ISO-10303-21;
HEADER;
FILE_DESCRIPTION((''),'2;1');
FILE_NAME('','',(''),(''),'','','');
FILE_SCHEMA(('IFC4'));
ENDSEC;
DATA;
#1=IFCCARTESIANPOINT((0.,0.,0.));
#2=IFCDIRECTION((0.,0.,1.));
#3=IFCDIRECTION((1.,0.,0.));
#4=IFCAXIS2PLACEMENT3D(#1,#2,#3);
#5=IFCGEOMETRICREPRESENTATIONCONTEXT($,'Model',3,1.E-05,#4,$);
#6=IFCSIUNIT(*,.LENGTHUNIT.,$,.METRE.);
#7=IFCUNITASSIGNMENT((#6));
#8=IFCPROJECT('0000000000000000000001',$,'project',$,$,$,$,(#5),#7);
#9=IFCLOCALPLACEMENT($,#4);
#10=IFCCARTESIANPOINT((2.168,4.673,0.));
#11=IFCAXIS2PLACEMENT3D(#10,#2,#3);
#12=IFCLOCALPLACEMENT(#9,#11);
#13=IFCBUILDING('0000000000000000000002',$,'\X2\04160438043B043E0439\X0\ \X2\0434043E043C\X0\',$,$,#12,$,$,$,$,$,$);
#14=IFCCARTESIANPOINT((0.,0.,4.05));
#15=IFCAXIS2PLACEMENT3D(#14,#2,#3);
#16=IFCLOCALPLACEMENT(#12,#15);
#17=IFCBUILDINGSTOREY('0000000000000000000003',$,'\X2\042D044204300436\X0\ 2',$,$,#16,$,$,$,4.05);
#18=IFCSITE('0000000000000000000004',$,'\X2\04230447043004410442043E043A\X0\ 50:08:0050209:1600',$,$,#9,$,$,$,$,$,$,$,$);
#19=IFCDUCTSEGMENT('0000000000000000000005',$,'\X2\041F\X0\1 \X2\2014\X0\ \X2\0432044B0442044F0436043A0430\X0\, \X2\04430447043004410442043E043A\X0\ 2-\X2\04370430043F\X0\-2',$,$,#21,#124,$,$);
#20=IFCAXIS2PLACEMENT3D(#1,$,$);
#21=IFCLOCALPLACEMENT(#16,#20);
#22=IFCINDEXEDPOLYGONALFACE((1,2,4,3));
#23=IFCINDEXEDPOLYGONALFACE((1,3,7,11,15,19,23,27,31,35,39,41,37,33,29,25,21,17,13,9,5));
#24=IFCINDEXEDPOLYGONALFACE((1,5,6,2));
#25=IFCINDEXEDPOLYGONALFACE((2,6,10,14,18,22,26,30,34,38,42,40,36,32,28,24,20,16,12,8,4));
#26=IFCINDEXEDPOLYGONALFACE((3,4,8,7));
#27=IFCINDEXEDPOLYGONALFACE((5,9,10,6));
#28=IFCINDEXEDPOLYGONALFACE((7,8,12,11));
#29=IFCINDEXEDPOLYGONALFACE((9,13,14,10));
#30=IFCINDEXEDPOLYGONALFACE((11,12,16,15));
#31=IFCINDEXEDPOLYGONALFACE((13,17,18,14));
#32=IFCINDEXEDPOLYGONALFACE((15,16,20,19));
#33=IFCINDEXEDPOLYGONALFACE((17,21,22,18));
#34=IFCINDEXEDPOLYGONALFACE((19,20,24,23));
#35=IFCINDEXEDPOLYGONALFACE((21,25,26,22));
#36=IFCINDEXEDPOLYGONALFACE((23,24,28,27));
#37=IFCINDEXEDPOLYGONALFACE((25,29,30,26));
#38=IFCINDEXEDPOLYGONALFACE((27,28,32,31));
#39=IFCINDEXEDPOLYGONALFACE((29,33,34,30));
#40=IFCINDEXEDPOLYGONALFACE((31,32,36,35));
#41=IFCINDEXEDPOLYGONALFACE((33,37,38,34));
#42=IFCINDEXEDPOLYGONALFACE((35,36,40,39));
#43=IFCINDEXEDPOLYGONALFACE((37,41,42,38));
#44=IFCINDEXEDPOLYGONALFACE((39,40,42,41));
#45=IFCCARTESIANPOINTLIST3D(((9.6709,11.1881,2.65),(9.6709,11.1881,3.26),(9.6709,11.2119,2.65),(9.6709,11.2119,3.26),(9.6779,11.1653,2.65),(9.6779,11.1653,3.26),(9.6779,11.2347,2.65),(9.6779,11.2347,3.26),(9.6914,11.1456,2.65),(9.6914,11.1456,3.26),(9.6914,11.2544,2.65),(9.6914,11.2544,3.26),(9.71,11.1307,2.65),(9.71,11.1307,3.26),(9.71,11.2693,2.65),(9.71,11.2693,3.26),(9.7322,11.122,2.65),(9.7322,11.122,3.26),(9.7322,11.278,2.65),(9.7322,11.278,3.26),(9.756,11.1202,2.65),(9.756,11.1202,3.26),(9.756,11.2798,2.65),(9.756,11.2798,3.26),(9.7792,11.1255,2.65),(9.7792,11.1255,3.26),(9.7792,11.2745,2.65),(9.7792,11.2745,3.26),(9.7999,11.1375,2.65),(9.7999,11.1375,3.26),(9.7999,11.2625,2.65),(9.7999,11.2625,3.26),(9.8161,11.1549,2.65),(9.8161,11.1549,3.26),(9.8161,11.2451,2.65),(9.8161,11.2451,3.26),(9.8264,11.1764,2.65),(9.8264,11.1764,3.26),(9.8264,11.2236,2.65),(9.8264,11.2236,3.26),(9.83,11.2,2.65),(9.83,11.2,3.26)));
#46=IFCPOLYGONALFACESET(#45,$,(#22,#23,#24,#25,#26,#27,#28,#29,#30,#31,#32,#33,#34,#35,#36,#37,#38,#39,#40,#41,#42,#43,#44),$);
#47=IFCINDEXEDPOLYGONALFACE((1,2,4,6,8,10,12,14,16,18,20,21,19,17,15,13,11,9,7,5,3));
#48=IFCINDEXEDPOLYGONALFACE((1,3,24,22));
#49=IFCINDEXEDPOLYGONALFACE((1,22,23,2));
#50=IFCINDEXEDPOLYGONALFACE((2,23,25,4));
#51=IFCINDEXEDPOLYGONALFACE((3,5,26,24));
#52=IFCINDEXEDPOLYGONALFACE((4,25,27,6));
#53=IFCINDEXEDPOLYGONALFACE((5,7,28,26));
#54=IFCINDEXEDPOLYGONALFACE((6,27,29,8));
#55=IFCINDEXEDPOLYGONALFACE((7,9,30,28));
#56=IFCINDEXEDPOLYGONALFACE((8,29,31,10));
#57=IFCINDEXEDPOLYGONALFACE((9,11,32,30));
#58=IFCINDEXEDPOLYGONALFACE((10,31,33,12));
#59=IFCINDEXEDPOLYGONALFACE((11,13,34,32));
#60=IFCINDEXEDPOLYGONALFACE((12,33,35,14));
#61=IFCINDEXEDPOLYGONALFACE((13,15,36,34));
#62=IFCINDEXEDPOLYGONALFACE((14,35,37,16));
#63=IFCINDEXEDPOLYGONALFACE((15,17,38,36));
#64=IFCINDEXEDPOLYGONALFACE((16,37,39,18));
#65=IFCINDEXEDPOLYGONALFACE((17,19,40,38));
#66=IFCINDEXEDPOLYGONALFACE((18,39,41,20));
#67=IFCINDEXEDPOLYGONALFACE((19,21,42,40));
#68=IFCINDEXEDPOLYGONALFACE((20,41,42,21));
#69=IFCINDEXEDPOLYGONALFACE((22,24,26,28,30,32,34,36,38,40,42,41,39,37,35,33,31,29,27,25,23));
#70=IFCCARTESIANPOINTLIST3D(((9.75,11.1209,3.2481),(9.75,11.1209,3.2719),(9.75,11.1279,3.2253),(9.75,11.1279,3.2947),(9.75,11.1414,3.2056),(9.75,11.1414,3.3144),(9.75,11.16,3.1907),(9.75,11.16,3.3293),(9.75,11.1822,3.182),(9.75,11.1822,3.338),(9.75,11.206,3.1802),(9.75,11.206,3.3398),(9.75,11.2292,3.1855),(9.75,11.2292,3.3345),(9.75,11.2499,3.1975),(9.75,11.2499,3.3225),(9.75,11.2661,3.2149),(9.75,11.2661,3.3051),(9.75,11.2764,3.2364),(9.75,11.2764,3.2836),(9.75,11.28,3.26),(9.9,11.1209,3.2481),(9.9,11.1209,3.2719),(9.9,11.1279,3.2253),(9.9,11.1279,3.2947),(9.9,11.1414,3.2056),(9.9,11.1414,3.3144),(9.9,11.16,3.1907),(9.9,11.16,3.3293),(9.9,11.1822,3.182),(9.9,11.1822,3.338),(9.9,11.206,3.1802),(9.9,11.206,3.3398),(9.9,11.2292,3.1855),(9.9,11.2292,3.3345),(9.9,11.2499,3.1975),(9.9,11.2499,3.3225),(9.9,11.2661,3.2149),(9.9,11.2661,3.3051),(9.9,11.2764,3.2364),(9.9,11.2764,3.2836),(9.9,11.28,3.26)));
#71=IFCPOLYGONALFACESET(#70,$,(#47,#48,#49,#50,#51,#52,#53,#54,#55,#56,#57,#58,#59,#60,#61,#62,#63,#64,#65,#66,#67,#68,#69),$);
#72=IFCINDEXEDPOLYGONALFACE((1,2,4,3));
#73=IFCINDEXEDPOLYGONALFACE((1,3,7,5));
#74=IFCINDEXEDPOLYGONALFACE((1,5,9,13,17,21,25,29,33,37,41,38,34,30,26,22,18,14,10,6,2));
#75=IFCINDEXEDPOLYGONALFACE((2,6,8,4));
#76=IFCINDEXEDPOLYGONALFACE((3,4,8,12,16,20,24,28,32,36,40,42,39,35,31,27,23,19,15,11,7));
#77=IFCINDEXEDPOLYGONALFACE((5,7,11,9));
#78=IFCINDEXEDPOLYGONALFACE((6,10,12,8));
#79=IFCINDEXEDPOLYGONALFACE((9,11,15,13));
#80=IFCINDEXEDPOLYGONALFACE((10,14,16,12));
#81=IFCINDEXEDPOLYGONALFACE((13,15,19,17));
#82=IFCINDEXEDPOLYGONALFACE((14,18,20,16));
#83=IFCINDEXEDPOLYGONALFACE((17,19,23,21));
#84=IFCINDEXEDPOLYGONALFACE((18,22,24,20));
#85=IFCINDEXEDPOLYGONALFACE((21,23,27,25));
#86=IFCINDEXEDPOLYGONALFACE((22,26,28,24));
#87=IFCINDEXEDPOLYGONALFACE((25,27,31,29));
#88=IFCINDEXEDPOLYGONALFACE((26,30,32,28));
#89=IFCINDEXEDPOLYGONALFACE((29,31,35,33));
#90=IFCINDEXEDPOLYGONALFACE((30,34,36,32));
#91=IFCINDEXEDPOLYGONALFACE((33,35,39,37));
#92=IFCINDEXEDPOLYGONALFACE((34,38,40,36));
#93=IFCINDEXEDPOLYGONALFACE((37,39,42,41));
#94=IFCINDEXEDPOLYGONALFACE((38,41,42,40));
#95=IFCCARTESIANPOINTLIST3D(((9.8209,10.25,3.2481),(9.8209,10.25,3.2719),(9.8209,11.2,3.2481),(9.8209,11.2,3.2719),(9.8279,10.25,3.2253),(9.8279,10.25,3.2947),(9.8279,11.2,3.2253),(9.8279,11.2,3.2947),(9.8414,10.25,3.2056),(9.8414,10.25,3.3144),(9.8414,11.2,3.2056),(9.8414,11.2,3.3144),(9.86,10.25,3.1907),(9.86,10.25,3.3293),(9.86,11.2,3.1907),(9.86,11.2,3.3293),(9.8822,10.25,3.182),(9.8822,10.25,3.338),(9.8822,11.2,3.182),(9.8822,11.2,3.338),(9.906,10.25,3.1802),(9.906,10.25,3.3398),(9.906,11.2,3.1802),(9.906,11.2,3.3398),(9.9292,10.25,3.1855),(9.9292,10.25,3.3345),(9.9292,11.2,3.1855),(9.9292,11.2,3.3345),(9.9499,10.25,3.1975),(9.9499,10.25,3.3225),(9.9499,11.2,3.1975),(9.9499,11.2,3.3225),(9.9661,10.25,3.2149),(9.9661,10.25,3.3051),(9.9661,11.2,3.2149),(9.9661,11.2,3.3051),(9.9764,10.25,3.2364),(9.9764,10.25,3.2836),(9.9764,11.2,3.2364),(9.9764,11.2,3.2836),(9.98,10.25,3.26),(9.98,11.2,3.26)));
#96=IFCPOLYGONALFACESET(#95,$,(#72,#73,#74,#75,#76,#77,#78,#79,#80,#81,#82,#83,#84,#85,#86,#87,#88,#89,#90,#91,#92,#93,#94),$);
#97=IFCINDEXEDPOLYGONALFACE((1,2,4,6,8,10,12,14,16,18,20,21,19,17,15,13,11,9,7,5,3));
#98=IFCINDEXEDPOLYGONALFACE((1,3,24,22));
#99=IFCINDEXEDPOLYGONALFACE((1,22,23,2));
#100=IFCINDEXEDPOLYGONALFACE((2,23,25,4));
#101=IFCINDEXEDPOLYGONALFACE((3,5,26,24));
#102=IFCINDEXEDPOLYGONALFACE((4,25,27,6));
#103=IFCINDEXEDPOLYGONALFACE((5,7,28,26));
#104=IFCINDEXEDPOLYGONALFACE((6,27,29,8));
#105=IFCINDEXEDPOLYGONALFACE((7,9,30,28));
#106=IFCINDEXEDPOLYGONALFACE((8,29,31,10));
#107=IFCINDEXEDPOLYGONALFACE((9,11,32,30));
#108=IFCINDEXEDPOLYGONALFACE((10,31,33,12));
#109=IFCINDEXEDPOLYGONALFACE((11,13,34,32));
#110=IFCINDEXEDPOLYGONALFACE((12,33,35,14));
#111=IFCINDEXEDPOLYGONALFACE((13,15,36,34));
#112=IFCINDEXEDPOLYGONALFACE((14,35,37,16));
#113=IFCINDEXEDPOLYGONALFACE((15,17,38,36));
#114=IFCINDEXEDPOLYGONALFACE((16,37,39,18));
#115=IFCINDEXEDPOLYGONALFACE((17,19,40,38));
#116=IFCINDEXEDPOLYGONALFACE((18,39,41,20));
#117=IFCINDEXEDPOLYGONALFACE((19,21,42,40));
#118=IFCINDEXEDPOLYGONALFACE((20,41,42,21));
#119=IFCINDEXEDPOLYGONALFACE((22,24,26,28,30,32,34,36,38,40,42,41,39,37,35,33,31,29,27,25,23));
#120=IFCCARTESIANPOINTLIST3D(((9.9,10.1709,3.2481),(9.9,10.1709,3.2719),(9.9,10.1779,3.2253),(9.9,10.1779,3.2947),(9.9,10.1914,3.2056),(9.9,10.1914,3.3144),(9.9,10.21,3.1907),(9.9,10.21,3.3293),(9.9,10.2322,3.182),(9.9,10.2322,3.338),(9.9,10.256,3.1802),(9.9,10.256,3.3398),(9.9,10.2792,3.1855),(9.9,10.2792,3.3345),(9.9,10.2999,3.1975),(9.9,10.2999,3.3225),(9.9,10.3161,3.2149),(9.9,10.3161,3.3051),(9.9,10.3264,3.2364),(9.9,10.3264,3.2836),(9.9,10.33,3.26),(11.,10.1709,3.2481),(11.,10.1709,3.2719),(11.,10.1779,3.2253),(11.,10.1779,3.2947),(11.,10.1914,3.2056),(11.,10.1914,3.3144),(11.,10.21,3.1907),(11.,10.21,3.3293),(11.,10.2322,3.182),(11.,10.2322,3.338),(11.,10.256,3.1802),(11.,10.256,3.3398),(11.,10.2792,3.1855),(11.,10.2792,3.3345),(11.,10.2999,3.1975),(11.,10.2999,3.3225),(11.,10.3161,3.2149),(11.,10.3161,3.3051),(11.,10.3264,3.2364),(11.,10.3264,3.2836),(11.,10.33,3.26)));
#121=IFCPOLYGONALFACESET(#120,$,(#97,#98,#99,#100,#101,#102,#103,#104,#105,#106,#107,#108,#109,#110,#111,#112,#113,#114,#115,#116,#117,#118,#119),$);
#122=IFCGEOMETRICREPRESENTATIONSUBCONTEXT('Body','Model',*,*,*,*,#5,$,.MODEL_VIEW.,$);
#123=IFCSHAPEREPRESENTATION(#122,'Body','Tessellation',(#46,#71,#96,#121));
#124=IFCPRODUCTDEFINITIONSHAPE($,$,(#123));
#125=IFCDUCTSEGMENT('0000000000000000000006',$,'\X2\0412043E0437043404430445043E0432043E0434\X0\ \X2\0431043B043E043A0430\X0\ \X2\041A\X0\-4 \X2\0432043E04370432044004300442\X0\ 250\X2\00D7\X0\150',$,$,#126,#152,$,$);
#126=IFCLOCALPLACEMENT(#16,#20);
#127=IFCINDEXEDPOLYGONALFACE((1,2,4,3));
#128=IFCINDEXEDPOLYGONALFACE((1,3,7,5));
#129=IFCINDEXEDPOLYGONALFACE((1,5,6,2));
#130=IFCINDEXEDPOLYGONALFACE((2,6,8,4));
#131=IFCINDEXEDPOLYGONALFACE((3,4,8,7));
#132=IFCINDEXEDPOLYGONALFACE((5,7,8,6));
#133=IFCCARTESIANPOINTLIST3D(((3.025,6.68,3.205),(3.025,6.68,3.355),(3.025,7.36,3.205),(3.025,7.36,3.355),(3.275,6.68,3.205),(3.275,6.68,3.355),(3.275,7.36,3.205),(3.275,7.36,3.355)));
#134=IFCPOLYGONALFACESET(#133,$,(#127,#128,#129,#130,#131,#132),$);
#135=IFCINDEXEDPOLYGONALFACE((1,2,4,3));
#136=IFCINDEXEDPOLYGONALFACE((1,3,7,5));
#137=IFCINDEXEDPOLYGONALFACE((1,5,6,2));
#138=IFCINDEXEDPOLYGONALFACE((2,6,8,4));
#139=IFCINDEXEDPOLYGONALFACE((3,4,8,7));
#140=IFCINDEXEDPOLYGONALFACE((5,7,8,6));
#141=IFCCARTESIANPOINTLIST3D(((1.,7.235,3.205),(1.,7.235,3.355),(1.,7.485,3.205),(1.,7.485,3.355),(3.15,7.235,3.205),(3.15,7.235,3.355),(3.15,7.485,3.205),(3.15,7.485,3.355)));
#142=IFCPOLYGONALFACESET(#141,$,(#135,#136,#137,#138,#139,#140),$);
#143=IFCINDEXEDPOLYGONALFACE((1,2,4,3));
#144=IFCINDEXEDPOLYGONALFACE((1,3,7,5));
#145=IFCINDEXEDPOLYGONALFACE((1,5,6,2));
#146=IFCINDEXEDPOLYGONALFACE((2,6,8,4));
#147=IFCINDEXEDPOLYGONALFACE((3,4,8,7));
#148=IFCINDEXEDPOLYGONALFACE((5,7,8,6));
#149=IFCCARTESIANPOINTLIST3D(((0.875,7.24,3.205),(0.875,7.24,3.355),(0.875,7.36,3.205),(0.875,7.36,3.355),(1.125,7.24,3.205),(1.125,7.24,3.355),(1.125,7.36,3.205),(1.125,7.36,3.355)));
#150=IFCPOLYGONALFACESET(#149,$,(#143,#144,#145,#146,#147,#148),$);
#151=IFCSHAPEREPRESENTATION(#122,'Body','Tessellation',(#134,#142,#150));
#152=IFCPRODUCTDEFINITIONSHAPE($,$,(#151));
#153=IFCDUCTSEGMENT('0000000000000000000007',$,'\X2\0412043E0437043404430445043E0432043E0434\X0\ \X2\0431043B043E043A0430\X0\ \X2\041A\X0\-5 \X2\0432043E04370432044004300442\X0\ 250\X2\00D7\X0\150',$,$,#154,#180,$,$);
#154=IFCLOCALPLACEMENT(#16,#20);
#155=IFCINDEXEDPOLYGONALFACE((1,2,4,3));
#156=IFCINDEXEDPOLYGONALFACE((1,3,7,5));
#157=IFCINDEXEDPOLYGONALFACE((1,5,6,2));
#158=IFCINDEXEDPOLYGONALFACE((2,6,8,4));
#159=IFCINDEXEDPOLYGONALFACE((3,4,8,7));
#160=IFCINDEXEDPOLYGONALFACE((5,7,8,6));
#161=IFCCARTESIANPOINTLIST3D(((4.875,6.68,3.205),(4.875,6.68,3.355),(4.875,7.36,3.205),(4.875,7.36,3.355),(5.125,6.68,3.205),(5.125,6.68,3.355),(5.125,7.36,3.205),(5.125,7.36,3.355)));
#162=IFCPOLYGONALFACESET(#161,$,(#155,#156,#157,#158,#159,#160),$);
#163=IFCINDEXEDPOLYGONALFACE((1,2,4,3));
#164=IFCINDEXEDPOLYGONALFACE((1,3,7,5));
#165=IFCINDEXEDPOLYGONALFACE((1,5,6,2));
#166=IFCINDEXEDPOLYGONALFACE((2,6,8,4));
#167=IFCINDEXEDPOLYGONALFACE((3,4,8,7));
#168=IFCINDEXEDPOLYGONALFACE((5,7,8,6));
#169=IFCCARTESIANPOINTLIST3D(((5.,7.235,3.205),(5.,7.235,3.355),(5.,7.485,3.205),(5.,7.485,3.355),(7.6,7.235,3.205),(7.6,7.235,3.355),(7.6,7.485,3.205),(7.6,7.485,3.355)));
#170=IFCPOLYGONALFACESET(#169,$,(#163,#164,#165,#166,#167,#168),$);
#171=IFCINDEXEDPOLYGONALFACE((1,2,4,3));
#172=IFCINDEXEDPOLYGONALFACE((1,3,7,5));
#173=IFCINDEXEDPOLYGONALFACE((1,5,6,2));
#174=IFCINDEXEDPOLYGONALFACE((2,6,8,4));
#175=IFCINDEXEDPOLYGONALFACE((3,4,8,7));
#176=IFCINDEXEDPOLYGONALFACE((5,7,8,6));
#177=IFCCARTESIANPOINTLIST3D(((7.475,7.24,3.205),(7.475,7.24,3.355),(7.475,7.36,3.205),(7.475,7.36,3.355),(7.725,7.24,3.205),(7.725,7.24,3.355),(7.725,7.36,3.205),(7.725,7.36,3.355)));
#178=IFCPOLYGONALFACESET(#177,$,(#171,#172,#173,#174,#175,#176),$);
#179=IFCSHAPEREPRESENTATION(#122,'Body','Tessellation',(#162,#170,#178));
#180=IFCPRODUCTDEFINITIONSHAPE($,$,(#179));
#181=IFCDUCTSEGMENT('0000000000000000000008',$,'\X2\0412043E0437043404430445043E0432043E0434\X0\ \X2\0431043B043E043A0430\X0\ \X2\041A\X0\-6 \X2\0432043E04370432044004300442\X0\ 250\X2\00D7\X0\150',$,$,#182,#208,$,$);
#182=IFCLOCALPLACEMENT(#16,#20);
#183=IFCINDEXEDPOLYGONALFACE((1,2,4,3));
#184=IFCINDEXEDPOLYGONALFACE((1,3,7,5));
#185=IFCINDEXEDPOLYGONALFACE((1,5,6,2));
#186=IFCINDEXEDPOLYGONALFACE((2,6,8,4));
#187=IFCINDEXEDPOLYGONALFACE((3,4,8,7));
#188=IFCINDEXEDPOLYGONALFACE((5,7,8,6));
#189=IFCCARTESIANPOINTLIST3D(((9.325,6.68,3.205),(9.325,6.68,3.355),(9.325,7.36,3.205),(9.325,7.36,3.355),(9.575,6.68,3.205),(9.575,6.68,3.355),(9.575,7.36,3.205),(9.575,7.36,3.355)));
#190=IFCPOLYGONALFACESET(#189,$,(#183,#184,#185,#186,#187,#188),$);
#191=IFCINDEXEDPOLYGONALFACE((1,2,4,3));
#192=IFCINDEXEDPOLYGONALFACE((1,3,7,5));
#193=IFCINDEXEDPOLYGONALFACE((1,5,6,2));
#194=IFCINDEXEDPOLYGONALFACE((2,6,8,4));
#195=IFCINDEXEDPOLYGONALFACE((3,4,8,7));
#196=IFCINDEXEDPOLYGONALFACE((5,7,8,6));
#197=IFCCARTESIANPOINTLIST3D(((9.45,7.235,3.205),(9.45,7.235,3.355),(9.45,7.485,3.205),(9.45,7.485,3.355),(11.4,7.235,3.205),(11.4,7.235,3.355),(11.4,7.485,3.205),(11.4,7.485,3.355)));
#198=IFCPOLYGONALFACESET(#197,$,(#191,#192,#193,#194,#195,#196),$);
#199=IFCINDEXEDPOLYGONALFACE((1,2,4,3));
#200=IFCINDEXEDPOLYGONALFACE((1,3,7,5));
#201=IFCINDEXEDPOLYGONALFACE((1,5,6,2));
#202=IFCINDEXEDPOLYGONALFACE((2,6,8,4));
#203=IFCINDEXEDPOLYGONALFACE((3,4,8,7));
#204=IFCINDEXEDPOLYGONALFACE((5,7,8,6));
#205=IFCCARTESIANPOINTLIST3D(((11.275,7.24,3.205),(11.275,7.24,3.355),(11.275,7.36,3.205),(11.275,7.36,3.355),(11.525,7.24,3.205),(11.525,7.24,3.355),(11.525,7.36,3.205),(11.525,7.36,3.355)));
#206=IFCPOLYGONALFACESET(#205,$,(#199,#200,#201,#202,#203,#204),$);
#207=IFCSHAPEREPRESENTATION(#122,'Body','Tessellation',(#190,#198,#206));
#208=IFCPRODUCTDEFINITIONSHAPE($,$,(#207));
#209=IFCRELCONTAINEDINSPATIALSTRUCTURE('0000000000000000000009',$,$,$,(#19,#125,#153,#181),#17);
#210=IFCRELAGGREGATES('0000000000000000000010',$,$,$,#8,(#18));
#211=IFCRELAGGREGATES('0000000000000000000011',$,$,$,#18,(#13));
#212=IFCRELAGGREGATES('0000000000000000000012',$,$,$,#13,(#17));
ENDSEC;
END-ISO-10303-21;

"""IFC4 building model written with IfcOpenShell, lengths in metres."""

from ifc_helpers import new_model, si_unit, frame, origin_with_axes, origin_2d, place, context, subcontext, project, spatial, rectangle, circle, extrude, element, save


model = new_model("IFC4")

# Units and contexts
model_context = context("Model", 3, precision=1e-05, world=origin_with_axes())
body_context = subcontext(model_context, "Body", "Model", "MODEL_VIEW")
ifc_project = project(units=[si_unit("LENGTHUNIT", "METRE")], contexts=[model_context])

# Site, building, storey
site_placement = place(None, origin_with_axes())
site = spatial("IfcSite", under=ifc_project, at=site_placement, Name="Участок 50:08:0050209:1600")
building_placement = place(site_placement, frame((2.168, 4.673, 0.0), z_axis=(0.0, 0.0, 1.0), x_axis=(1.0, 0.0, 0.0)))
building = spatial("IfcBuilding", under=site, at=building_placement, Name="Жилой дом")
storey_placement = place(building_placement, frame((0.0, 0.0, 4.05), z_axis=(0.0, 0.0, 1.0), x_axis=(1.0, 0.0, 0.0)))
storey = spatial("IfcBuildingStorey", under=building, at=storey_placement, Name="Этаж 2", Elevation=4.05)

# Duct segments
duct_segment_1_placement = place(storey_placement, frame((0.0, 0.0, -4.05), z_axis=(0.0, 0.0, 1.0), x_axis=(1.0, 0.0, 0.0)))
element("IfcDuctSegment", 1, at=duct_segment_1_placement, inside=storey, Name="П1 — вытяжка, участок 2-зап-2", context=body_context, shape_type="SweptSolid", body=[
    extrude(circle(Radius=0.08, at=origin_2d()), frame((9.75, 11.2, 6.7), z_axis=(0.0, 0.0, 1.0), x_axis=(1.0, 0.0, 0.0)), (0.0, 0.0, 1.0), 0.61),
    extrude(circle(Radius=0.08, at=origin_2d()), frame((9.75, 11.2, 7.31), z_axis=(1.0, 0.0, 0.0), x_axis=(0.0, 1.0, 0.0)), (0.0, 0.0, 1.0), 0.15),
    extrude(circle(Radius=0.08, at=origin_2d()), frame((9.9, 11.2, 7.31), z_axis=(0.0, -1.0, 0.0), x_axis=(1.0, 0.0, 0.0)), (0.0, 0.0, 1.0), 0.95),
    extrude(circle(Radius=0.08, at=origin_2d()), frame((9.9, 10.25, 7.31), z_axis=(1.0, 0.0, 0.0), x_axis=(0.0, 1.0, 0.0)), (0.0, 0.0, 1.0), 1.1),
])
duct_segment_2_placement = place(storey_placement, frame((0.0, 0.0, -4.05), z_axis=(0.0, 0.0, 1.0), x_axis=(1.0, 0.0, 0.0)))
element("IfcDuctSegment", 2, at=duct_segment_2_placement, inside=storey, Name="Воздуховод блока К-4 возврат 250×150", context=body_context, shape_type="SweptSolid", body=[
    extrude(rectangle(XDim=0.25, YDim=0.15, at=origin_2d()), frame((3.15, 6.68, 7.33), z_axis=(0.0, 1.0, 0.0), x_axis=(-1.0, 0.0, 0.0)), (0.0, 0.0, 1.0), 0.68),
    extrude(rectangle(XDim=0.25, YDim=0.15, at=origin_2d()), frame((3.15, 7.36, 7.33), z_axis=(-1.0, 0.0, 0.0), x_axis=(0.0, -1.0, 0.0)), (0.0, 0.0, 1.0), 2.15),
    extrude(rectangle(XDim=0.25, YDim=0.15, at=origin_2d()), frame((1.0, 7.36, 7.33), z_axis=(0.0, -1.0, 0.0), x_axis=(1.0, 0.0, 0.0)), (0.0, 0.0, 1.0), 0.12),
])
duct_segment_3_placement = place(storey_placement, frame((0.0, 0.0, -4.05), z_axis=(0.0, 0.0, 1.0), x_axis=(1.0, 0.0, 0.0)))
element("IfcDuctSegment", 3, at=duct_segment_3_placement, inside=storey, Name="Воздуховод блока К-5 возврат 250×150", context=body_context, shape_type="SweptSolid", body=[
    extrude(rectangle(XDim=0.25, YDim=0.15, at=origin_2d()), frame((5.0, 6.68, 7.33), z_axis=(0.0, 1.0, 0.0), x_axis=(-1.0, 0.0, 0.0)), (0.0, 0.0, 1.0), 0.68),
    extrude(rectangle(XDim=0.25, YDim=0.15, at=origin_2d()), frame((5.0, 7.36, 7.33), z_axis=(1.0, 0.0, 0.0), x_axis=(0.0, 1.0, 0.0)), (0.0, 0.0, 1.0), 2.6),
    extrude(rectangle(XDim=0.25, YDim=0.15, at=origin_2d()), frame((7.6, 7.36, 7.33), z_axis=(0.0, -1.0, 0.0), x_axis=(1.0, 0.0, 0.0)), (0.0, 0.0, 1.0), 0.12),
])
duct_segment_4_placement = place(storey_placement, frame((0.0, 0.0, -4.05), z_axis=(0.0, 0.0, 1.0), x_axis=(1.0, 0.0, 0.0)))
element("IfcDuctSegment", 4, at=duct_segment_4_placement, inside=storey, Name="Воздуховод блока К-6 возврат 250×150", context=body_context, shape_type="SweptSolid", body=[
    extrude(rectangle(XDim=0.25, YDim=0.15, at=origin_2d()), frame((9.45, 6.68, 7.33), z_axis=(0.0, 1.0, 0.0), x_axis=(-1.0, 0.0, 0.0)), (0.0, 0.0, 1.0), 0.68),
    extrude(rectangle(XDim=0.25, YDim=0.15, at=origin_2d()), frame((9.45, 7.36, 7.33), z_axis=(1.0, 0.0, 0.0), x_axis=(0.0, 1.0, 0.0)), (0.0, 0.0, 1.0), 1.95),
    extrude(rectangle(XDim=0.25, YDim=0.15, at=origin_2d()), frame((11.4, 7.36, 7.33), z_axis=(0.0, -1.0, 0.0), x_axis=(1.0, 0.0, 0.0)), (0.0, 0.0, 1.0), 0.12),
])

save(model, "model.ifc")
